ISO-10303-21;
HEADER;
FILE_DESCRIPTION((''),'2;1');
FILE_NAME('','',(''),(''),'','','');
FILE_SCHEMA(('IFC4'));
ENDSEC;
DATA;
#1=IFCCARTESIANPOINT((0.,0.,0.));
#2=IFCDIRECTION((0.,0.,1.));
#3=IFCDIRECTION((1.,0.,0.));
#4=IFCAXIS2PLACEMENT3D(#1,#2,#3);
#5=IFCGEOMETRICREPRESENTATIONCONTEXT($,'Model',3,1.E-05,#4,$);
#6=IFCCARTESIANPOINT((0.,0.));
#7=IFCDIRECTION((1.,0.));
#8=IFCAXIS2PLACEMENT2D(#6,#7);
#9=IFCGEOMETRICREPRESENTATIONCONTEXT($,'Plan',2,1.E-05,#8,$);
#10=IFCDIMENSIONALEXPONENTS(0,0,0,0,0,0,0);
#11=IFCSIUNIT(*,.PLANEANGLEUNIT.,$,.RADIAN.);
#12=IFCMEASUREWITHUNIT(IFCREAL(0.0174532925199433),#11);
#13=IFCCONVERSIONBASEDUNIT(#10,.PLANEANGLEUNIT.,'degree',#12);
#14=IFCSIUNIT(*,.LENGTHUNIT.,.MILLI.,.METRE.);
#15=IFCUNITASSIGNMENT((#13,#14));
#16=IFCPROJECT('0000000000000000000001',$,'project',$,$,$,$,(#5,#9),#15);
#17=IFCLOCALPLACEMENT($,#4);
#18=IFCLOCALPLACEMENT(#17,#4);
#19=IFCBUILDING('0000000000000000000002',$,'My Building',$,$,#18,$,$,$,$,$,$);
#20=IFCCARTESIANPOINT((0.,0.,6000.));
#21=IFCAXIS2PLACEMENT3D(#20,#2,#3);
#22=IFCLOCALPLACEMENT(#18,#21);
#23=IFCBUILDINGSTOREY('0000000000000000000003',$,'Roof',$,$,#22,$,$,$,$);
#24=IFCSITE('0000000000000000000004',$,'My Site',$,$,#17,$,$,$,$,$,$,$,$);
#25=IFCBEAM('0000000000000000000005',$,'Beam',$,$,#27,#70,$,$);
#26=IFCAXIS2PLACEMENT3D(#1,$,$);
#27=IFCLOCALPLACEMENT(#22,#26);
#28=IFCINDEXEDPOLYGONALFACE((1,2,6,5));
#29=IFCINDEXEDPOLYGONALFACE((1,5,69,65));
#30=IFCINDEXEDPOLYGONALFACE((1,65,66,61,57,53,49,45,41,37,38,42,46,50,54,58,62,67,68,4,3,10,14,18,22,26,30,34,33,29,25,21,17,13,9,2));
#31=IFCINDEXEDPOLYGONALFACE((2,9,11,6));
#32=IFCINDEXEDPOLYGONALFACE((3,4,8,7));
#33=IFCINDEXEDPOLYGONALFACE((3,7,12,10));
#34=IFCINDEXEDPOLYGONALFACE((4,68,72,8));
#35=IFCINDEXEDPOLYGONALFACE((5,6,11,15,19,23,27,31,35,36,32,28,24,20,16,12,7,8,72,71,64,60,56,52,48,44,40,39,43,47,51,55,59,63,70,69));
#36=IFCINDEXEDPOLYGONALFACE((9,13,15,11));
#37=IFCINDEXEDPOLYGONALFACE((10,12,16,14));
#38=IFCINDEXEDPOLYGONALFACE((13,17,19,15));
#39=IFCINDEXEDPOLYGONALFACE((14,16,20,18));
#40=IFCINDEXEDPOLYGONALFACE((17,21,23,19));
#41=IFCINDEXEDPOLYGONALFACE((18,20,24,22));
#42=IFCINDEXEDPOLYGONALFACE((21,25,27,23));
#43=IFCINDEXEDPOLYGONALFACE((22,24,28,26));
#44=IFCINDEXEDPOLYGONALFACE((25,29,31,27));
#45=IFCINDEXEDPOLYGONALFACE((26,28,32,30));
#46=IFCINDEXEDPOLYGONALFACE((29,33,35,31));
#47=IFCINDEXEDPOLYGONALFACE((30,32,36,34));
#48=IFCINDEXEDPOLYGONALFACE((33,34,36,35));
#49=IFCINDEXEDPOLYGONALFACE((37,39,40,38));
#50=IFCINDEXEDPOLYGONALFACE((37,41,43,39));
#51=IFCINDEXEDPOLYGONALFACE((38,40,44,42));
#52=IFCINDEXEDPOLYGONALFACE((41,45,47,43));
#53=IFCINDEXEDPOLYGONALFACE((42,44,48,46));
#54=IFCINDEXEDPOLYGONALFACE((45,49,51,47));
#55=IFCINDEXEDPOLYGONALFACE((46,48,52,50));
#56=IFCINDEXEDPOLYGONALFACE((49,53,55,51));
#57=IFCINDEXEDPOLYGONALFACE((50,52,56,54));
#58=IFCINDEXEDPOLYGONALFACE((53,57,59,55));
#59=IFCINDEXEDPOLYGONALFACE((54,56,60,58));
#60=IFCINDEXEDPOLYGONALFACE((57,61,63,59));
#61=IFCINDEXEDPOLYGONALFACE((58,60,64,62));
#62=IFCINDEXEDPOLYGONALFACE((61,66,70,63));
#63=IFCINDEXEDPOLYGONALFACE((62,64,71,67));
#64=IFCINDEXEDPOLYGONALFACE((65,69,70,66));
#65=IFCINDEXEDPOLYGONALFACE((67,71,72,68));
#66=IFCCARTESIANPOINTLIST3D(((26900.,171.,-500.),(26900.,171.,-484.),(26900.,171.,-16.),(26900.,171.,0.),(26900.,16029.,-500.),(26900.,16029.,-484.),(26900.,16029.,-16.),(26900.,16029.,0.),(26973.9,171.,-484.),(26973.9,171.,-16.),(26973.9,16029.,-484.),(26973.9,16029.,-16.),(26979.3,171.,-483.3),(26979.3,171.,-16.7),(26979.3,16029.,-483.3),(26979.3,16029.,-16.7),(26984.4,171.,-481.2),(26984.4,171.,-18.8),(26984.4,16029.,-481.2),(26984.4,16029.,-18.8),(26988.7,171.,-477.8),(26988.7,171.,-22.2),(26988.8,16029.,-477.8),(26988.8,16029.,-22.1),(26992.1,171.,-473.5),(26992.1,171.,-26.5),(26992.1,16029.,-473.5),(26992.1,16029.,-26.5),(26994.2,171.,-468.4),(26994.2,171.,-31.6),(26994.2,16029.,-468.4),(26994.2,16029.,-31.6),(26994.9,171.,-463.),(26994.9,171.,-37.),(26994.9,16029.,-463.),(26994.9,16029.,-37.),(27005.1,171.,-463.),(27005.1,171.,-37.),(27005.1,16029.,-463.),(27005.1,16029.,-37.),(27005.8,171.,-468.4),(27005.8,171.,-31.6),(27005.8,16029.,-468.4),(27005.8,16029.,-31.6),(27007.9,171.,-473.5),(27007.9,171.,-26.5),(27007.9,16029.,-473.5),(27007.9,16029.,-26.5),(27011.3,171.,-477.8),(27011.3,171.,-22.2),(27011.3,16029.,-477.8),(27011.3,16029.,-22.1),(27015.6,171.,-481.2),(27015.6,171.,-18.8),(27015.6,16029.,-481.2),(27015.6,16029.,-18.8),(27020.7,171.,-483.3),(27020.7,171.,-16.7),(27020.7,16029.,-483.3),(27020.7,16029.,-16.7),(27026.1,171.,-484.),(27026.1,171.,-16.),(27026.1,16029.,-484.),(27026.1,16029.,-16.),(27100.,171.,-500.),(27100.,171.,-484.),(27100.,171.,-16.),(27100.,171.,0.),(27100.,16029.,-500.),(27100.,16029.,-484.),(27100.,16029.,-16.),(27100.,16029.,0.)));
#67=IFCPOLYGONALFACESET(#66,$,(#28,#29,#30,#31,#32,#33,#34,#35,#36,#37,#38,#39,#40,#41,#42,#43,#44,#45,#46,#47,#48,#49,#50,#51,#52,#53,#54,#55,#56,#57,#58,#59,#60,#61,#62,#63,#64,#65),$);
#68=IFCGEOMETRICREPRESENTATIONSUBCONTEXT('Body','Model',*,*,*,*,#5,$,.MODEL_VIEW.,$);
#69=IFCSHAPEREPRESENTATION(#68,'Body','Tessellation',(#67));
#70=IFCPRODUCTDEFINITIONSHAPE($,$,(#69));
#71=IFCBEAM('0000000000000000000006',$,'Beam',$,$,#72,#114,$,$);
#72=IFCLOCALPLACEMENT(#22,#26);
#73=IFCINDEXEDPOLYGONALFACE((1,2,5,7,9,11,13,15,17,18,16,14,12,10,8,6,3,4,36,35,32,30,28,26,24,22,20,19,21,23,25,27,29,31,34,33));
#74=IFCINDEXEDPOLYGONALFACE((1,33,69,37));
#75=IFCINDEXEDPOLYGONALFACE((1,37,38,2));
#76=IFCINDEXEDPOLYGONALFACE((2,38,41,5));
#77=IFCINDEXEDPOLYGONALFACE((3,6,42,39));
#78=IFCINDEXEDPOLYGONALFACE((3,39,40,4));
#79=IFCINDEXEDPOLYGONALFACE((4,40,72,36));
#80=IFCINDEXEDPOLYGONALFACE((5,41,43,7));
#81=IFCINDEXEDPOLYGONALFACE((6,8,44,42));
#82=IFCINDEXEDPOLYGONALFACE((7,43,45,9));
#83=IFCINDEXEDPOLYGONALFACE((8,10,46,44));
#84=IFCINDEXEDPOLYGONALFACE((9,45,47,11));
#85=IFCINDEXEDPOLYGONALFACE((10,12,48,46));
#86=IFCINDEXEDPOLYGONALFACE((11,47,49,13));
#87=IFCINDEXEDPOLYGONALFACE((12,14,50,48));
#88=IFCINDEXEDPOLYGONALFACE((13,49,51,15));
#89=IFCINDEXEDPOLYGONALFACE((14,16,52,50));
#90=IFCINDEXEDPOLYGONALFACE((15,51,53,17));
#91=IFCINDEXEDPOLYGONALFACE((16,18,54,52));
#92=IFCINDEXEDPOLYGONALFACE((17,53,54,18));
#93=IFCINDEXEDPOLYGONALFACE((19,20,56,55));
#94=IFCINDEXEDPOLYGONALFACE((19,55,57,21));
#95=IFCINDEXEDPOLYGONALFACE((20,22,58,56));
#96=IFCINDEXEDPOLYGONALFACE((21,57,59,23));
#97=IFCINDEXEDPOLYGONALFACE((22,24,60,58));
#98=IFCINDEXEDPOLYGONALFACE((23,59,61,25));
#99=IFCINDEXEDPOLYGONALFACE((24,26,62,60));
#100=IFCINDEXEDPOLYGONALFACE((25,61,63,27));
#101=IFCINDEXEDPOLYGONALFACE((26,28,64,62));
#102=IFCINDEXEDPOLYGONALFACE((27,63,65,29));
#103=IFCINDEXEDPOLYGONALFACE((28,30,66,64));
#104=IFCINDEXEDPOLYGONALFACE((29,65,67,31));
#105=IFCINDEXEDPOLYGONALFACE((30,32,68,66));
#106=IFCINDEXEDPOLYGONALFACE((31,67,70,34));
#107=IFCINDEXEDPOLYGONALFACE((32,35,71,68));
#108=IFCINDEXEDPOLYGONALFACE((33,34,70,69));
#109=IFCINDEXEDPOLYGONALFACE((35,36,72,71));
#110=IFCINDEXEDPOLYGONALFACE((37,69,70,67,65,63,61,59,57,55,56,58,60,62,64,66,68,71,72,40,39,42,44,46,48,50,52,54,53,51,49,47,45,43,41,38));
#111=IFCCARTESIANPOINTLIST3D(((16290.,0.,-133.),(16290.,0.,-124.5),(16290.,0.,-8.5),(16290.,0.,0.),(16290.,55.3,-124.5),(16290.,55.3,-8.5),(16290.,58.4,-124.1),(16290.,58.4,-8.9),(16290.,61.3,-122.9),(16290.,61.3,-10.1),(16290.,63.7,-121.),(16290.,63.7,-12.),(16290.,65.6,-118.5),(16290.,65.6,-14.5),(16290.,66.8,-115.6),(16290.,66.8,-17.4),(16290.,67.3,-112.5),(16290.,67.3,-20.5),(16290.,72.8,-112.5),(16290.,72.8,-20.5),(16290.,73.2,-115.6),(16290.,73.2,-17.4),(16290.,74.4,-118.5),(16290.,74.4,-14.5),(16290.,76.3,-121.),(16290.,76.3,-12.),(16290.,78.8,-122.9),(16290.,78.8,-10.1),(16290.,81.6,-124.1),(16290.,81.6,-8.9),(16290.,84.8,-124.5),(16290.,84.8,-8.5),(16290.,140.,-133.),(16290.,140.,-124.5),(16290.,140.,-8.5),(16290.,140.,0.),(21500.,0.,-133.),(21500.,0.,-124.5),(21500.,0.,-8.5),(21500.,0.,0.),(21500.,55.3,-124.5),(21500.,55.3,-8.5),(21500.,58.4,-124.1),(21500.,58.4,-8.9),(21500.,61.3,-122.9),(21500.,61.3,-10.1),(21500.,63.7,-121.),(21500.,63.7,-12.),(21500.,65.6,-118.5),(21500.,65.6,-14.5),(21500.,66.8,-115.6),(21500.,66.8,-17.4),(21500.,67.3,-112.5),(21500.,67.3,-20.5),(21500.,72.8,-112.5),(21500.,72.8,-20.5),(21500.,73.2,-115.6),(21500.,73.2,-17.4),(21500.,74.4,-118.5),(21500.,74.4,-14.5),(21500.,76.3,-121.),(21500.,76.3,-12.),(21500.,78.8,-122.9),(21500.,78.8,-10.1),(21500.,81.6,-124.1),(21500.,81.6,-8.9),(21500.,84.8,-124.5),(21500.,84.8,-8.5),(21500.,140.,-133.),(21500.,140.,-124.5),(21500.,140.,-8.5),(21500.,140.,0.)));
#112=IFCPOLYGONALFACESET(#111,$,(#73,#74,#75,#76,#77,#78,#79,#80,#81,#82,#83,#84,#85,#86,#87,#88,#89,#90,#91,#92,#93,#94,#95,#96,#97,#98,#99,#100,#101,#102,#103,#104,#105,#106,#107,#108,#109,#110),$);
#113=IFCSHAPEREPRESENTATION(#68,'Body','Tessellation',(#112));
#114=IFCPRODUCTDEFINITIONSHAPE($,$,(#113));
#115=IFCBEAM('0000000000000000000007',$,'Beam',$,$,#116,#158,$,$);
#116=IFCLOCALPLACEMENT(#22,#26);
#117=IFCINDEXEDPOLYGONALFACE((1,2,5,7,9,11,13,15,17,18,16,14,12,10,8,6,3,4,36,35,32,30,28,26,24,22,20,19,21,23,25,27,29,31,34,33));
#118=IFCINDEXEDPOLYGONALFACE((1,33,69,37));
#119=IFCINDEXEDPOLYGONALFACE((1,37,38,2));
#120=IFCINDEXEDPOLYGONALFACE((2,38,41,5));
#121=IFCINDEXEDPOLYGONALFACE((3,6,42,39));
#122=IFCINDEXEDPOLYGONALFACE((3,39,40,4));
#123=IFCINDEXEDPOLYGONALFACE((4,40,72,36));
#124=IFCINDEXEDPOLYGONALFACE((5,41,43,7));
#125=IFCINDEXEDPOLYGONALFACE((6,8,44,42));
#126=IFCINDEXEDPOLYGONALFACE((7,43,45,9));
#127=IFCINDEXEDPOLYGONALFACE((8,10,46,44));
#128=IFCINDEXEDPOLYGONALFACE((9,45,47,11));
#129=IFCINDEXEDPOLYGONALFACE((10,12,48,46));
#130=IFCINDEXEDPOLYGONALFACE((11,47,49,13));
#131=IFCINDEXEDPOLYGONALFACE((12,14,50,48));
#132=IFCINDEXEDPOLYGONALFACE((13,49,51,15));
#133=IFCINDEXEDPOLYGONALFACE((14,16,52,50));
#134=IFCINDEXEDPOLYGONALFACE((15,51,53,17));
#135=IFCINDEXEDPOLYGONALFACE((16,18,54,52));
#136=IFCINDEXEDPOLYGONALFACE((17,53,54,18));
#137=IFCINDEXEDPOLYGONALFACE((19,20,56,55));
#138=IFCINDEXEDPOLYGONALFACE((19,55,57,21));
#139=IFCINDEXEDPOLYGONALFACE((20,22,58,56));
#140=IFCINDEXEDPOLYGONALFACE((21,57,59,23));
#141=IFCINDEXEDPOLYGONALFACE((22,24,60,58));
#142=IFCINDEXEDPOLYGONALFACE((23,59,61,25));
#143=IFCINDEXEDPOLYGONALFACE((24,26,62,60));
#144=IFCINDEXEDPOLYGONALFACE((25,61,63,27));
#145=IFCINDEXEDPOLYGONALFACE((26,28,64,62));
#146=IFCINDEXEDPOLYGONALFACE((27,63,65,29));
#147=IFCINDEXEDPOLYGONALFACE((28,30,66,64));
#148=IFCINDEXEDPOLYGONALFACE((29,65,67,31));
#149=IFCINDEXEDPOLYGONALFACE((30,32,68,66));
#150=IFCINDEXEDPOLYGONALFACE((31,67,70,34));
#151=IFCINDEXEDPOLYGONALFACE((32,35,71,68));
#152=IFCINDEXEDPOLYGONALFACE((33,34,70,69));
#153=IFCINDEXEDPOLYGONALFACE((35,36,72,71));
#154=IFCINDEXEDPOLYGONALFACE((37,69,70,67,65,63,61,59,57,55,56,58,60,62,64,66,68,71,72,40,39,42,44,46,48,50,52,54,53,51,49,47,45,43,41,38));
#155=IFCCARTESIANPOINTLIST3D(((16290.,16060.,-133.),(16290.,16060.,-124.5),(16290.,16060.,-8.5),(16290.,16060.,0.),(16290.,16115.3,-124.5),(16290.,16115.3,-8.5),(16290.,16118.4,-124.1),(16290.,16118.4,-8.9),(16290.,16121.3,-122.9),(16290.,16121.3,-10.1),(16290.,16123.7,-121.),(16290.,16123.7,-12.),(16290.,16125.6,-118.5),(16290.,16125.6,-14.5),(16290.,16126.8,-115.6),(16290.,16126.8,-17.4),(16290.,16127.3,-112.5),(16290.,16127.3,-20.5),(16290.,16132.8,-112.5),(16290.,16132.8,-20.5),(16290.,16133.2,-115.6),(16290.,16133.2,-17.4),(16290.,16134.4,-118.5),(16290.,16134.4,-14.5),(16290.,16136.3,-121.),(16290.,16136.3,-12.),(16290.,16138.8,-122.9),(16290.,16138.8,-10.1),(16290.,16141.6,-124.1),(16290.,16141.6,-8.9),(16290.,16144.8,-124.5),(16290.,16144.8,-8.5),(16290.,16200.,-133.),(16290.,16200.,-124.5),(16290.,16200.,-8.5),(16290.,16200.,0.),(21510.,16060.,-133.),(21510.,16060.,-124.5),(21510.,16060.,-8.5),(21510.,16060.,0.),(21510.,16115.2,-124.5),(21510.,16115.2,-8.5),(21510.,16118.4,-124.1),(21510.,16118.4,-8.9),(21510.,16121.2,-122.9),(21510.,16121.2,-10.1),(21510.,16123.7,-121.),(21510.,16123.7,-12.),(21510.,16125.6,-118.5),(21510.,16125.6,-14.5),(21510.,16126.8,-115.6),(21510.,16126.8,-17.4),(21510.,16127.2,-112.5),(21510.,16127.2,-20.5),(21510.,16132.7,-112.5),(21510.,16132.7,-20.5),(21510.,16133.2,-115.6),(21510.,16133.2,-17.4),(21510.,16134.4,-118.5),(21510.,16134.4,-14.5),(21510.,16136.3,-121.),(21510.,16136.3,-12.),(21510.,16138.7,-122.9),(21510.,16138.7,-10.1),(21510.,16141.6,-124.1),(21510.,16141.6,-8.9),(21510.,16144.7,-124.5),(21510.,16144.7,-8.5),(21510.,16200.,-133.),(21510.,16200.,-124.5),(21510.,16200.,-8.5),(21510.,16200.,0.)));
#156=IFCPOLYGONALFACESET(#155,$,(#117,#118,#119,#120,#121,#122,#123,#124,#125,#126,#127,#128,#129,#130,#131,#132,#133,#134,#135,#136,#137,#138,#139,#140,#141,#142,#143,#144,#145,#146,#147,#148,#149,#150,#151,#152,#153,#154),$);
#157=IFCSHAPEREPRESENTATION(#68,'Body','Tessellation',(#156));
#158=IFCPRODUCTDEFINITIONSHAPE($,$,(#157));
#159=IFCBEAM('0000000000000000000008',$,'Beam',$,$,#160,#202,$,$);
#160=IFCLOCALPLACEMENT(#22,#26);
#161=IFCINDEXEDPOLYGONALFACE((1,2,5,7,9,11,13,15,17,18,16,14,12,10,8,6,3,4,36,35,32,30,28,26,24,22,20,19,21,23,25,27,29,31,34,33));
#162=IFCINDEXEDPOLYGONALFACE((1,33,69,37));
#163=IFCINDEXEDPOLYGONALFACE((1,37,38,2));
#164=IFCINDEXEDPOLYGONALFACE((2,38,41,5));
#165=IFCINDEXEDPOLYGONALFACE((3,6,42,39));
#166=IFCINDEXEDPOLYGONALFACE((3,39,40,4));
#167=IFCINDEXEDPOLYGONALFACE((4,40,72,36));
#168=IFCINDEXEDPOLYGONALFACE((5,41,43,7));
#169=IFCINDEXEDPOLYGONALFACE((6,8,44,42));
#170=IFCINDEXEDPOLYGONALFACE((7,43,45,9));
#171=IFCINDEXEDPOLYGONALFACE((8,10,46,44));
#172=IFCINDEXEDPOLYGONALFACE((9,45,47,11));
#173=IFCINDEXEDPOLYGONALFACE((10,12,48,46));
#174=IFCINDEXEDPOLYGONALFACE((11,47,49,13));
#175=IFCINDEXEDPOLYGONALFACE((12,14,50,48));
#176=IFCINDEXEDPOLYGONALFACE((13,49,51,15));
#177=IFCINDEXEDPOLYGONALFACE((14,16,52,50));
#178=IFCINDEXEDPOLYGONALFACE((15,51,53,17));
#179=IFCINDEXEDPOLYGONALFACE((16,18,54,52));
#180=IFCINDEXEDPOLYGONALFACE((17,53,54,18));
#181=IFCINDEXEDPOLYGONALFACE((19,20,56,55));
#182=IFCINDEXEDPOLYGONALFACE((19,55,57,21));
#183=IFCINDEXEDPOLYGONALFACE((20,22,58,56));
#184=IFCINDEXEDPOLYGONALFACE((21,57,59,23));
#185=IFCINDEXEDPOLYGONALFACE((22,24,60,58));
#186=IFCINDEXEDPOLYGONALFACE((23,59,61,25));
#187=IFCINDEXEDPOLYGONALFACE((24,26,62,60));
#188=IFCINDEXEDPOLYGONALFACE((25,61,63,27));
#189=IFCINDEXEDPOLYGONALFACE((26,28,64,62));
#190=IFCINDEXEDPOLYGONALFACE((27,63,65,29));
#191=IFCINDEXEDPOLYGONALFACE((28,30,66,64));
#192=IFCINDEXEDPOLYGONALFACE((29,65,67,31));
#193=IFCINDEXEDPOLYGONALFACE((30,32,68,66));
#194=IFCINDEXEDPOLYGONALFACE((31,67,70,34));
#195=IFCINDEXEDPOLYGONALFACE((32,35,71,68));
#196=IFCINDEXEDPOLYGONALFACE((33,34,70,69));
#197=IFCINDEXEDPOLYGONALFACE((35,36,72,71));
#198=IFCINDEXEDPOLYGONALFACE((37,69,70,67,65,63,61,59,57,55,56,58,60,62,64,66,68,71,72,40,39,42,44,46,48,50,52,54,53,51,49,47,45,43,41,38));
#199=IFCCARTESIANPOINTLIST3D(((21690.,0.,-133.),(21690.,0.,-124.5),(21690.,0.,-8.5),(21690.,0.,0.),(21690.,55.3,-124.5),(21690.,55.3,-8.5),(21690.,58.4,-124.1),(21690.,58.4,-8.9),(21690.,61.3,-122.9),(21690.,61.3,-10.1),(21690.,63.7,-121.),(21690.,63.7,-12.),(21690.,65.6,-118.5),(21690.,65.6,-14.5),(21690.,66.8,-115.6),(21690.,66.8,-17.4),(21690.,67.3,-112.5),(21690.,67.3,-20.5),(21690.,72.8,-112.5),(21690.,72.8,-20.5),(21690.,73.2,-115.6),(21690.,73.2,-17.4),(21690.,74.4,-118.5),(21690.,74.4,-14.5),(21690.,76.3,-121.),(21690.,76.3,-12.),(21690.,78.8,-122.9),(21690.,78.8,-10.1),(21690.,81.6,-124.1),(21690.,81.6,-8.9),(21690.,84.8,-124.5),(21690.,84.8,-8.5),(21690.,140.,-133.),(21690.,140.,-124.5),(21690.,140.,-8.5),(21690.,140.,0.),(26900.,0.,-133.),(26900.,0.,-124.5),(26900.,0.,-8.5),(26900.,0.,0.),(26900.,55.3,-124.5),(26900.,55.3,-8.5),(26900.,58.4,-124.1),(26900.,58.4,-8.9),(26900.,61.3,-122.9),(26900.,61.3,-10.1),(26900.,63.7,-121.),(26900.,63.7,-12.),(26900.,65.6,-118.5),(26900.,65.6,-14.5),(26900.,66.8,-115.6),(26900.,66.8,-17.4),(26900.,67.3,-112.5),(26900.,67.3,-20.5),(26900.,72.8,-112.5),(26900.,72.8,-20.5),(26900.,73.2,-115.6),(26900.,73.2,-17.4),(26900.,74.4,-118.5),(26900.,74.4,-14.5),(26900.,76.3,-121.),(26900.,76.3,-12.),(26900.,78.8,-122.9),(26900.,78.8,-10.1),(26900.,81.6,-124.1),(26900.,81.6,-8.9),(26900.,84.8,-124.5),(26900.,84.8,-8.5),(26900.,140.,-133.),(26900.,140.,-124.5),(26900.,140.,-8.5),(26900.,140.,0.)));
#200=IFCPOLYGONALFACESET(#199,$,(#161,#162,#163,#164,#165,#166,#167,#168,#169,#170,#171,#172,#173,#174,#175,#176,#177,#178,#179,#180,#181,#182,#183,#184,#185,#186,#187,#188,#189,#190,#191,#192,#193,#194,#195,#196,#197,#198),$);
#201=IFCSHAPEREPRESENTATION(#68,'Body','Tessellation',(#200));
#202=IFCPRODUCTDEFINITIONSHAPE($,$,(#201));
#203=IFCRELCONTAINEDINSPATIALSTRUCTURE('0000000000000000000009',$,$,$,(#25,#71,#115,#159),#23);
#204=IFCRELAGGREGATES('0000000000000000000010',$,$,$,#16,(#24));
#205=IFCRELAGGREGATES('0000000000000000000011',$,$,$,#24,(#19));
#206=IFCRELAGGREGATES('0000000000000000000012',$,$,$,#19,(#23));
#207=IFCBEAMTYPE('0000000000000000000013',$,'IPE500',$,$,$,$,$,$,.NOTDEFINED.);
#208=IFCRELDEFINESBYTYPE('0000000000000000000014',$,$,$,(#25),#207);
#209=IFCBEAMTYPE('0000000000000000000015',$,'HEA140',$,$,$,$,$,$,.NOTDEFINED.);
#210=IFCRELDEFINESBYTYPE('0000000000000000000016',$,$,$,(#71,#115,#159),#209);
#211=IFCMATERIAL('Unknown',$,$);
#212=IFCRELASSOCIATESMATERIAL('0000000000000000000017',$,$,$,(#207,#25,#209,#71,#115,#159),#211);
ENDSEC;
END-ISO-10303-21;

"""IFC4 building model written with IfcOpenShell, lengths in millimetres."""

from ifc_helpers import new_model, entity, si_unit, converted_unit, frame, origin_with_axes, origin_2d_with_axis, place, context, subcontext, project, spatial, i_section, extrude, material, material_profile, profile_set, profile_usage, type_object, element, save


model = new_model("IFC4")

# Units and contexts
model_context = context("Model", 3, precision=1e-05, world=origin_with_axes())
plan_context = context("Plan", 2, precision=1e-05, world=origin_2d_with_axis())
body_context = subcontext(model_context, "Body", "Model", "MODEL_VIEW")
ifc_project = project(units=[converted_unit("PLANEANGLEUNIT", "degree", entity("IfcReal", 0.0174532925199433), si_unit("PLANEANGLEUNIT", "RADIAN"), dimensions=[0, 0, 0, 0, 0, 0, 0]), si_unit("LENGTHUNIT", "METRE", prefix="MILLI")], contexts=[model_context, plan_context])

# Site, building, storey
site_placement = place(None, origin_with_axes())
site = spatial("IfcSite", under=ifc_project, at=site_placement, Name="My Site")
building_placement = place(site_placement, origin_with_axes())
building = spatial("IfcBuilding", under=site, at=building_placement, Name="My Building")
storey_placement = place(building_placement, frame((0.0, 0.0, 6000.0), z_axis=(0.0, 0.0, 1.0), x_axis=(1.0, 0.0, 0.0)))
storey = spatial("IfcBuildingStorey", under=building, at=storey_placement, Name="Roof")

# Beams
ifc_material = material(Name="Unknown")
ifc_material_profile_1 = material_profile(ifc_material, i_section(OverallWidth=200.0, OverallDepth=500.0, WebThickness=10.2, FlangeThickness=16.0, FilletRadius=21.0))
ifc_profile_set_1 = profile_set([ifc_material_profile_1])
beam_type_1 = type_object("IfcBeamType", Name="IPE500", PredefinedType="NOTDEFINED", material=ifc_profile_set_1)
ifc_profile_usage_1 = profile_usage(ifc_profile_set_1, cardinal=8)
beam_1_placement = place(storey_placement, frame((27000.0, 171.0, 0.0), z_axis=(0.0, 1.0, 0.0), x_axis=(-1.0, 0.0, 0.0)))
element("IfcBeam", 1, at=beam_1_placement, inside=storey, type_object=beam_type_1, material=ifc_profile_usage_1, Name="Beam", context=body_context, shape_type="SweptSolid", body=[
    extrude(i_section(OverallWidth=200.0, OverallDepth=500.0, WebThickness=10.2, FlangeThickness=16.0, FilletRadius=21.0), frame((0.0, -250.0, 0.0), z_axis=(0.0, 0.0, 1.0), x_axis=(1.0, 0.0, 0.0)), (0.0, 0.0, 1.0), 15858.0),
])
ifc_material_profile_2 = material_profile(ifc_material, i_section(OverallWidth=140.0, OverallDepth=133.0, WebThickness=5.5, FlangeThickness=8.5, FilletRadius=12.0))
ifc_profile_set_2 = profile_set([ifc_material_profile_2])
ifc_profile_usage_2 = profile_usage(ifc_profile_set_2, cardinal=7)
beam_type_2 = type_object("IfcBeamType", Name="HEA140", PredefinedType="NOTDEFINED", material=ifc_profile_set_2)
beam_2_placement = place(storey_placement, frame((21500.0, 0.0, 0.0), z_axis=(-1.0, 0.0, 0.0), x_axis=(0.0, -1.0, 0.0)))
element("IfcBeam", 2, at=beam_2_placement, inside=storey, type_object=beam_type_2, material=ifc_profile_usage_2, Name="Beam", context=body_context, shape_type="SweptSolid", body=[
    extrude(i_section(OverallWidth=140.0, OverallDepth=133.0, WebThickness=5.5, FlangeThickness=8.5, FilletRadius=12.0), frame((-70.0, -66.5, 0.0), z_axis=(0.0, 0.0, 1.0), x_axis=(1.0, 0.0, 0.0)), (0.0, 0.0, 1.0), 5210.0),
])
ifc_profile_usage_3 = profile_usage(ifc_profile_set_2, cardinal=7)
beam_3_placement = place(storey_placement, frame((16290.0, 16200.0, 0.0), z_axis=(1.0, 0.0, 0.0), x_axis=(0.0, 1.0, 0.0)))
element("IfcBeam", 3, at=beam_3_placement, inside=storey, type_object=beam_type_2, material=ifc_profile_usage_3, Name="Beam", context=body_context, shape_type="SweptSolid", body=[
    extrude(i_section(OverallWidth=140.0, OverallDepth=133.0, WebThickness=5.5, FlangeThickness=8.5, FilletRadius=12.0), frame((-70.0, -66.5, 0.0), z_axis=(0.0, 0.0, 1.0), x_axis=(1.0, 0.0, 0.0)), (0.0, 0.0, 1.0), 5220.0),
])
ifc_profile_usage_4 = profile_usage(ifc_profile_set_2, cardinal=7)
beam_4_placement = place(storey_placement, frame((26900.0, 0.0, 0.0), z_axis=(-1.0, 0.0, 0.0), x_axis=(0.0, -1.0, 0.0)))
element("IfcBeam", 4, at=beam_4_placement, inside=storey, type_object=beam_type_2, material=ifc_profile_usage_4, Name="Beam", context=body_context, shape_type="SweptSolid", body=[
    extrude(i_section(OverallWidth=140.0, OverallDepth=133.0, WebThickness=5.5, FlangeThickness=8.5, FilletRadius=12.0), frame((-70.0, -66.5, 0.0), z_axis=(0.0, 0.0, 1.0), x_axis=(1.0, 0.0, 0.0)), (0.0, 0.0, 1.0), 5210.0),
])

save(model, "model.ifc")
